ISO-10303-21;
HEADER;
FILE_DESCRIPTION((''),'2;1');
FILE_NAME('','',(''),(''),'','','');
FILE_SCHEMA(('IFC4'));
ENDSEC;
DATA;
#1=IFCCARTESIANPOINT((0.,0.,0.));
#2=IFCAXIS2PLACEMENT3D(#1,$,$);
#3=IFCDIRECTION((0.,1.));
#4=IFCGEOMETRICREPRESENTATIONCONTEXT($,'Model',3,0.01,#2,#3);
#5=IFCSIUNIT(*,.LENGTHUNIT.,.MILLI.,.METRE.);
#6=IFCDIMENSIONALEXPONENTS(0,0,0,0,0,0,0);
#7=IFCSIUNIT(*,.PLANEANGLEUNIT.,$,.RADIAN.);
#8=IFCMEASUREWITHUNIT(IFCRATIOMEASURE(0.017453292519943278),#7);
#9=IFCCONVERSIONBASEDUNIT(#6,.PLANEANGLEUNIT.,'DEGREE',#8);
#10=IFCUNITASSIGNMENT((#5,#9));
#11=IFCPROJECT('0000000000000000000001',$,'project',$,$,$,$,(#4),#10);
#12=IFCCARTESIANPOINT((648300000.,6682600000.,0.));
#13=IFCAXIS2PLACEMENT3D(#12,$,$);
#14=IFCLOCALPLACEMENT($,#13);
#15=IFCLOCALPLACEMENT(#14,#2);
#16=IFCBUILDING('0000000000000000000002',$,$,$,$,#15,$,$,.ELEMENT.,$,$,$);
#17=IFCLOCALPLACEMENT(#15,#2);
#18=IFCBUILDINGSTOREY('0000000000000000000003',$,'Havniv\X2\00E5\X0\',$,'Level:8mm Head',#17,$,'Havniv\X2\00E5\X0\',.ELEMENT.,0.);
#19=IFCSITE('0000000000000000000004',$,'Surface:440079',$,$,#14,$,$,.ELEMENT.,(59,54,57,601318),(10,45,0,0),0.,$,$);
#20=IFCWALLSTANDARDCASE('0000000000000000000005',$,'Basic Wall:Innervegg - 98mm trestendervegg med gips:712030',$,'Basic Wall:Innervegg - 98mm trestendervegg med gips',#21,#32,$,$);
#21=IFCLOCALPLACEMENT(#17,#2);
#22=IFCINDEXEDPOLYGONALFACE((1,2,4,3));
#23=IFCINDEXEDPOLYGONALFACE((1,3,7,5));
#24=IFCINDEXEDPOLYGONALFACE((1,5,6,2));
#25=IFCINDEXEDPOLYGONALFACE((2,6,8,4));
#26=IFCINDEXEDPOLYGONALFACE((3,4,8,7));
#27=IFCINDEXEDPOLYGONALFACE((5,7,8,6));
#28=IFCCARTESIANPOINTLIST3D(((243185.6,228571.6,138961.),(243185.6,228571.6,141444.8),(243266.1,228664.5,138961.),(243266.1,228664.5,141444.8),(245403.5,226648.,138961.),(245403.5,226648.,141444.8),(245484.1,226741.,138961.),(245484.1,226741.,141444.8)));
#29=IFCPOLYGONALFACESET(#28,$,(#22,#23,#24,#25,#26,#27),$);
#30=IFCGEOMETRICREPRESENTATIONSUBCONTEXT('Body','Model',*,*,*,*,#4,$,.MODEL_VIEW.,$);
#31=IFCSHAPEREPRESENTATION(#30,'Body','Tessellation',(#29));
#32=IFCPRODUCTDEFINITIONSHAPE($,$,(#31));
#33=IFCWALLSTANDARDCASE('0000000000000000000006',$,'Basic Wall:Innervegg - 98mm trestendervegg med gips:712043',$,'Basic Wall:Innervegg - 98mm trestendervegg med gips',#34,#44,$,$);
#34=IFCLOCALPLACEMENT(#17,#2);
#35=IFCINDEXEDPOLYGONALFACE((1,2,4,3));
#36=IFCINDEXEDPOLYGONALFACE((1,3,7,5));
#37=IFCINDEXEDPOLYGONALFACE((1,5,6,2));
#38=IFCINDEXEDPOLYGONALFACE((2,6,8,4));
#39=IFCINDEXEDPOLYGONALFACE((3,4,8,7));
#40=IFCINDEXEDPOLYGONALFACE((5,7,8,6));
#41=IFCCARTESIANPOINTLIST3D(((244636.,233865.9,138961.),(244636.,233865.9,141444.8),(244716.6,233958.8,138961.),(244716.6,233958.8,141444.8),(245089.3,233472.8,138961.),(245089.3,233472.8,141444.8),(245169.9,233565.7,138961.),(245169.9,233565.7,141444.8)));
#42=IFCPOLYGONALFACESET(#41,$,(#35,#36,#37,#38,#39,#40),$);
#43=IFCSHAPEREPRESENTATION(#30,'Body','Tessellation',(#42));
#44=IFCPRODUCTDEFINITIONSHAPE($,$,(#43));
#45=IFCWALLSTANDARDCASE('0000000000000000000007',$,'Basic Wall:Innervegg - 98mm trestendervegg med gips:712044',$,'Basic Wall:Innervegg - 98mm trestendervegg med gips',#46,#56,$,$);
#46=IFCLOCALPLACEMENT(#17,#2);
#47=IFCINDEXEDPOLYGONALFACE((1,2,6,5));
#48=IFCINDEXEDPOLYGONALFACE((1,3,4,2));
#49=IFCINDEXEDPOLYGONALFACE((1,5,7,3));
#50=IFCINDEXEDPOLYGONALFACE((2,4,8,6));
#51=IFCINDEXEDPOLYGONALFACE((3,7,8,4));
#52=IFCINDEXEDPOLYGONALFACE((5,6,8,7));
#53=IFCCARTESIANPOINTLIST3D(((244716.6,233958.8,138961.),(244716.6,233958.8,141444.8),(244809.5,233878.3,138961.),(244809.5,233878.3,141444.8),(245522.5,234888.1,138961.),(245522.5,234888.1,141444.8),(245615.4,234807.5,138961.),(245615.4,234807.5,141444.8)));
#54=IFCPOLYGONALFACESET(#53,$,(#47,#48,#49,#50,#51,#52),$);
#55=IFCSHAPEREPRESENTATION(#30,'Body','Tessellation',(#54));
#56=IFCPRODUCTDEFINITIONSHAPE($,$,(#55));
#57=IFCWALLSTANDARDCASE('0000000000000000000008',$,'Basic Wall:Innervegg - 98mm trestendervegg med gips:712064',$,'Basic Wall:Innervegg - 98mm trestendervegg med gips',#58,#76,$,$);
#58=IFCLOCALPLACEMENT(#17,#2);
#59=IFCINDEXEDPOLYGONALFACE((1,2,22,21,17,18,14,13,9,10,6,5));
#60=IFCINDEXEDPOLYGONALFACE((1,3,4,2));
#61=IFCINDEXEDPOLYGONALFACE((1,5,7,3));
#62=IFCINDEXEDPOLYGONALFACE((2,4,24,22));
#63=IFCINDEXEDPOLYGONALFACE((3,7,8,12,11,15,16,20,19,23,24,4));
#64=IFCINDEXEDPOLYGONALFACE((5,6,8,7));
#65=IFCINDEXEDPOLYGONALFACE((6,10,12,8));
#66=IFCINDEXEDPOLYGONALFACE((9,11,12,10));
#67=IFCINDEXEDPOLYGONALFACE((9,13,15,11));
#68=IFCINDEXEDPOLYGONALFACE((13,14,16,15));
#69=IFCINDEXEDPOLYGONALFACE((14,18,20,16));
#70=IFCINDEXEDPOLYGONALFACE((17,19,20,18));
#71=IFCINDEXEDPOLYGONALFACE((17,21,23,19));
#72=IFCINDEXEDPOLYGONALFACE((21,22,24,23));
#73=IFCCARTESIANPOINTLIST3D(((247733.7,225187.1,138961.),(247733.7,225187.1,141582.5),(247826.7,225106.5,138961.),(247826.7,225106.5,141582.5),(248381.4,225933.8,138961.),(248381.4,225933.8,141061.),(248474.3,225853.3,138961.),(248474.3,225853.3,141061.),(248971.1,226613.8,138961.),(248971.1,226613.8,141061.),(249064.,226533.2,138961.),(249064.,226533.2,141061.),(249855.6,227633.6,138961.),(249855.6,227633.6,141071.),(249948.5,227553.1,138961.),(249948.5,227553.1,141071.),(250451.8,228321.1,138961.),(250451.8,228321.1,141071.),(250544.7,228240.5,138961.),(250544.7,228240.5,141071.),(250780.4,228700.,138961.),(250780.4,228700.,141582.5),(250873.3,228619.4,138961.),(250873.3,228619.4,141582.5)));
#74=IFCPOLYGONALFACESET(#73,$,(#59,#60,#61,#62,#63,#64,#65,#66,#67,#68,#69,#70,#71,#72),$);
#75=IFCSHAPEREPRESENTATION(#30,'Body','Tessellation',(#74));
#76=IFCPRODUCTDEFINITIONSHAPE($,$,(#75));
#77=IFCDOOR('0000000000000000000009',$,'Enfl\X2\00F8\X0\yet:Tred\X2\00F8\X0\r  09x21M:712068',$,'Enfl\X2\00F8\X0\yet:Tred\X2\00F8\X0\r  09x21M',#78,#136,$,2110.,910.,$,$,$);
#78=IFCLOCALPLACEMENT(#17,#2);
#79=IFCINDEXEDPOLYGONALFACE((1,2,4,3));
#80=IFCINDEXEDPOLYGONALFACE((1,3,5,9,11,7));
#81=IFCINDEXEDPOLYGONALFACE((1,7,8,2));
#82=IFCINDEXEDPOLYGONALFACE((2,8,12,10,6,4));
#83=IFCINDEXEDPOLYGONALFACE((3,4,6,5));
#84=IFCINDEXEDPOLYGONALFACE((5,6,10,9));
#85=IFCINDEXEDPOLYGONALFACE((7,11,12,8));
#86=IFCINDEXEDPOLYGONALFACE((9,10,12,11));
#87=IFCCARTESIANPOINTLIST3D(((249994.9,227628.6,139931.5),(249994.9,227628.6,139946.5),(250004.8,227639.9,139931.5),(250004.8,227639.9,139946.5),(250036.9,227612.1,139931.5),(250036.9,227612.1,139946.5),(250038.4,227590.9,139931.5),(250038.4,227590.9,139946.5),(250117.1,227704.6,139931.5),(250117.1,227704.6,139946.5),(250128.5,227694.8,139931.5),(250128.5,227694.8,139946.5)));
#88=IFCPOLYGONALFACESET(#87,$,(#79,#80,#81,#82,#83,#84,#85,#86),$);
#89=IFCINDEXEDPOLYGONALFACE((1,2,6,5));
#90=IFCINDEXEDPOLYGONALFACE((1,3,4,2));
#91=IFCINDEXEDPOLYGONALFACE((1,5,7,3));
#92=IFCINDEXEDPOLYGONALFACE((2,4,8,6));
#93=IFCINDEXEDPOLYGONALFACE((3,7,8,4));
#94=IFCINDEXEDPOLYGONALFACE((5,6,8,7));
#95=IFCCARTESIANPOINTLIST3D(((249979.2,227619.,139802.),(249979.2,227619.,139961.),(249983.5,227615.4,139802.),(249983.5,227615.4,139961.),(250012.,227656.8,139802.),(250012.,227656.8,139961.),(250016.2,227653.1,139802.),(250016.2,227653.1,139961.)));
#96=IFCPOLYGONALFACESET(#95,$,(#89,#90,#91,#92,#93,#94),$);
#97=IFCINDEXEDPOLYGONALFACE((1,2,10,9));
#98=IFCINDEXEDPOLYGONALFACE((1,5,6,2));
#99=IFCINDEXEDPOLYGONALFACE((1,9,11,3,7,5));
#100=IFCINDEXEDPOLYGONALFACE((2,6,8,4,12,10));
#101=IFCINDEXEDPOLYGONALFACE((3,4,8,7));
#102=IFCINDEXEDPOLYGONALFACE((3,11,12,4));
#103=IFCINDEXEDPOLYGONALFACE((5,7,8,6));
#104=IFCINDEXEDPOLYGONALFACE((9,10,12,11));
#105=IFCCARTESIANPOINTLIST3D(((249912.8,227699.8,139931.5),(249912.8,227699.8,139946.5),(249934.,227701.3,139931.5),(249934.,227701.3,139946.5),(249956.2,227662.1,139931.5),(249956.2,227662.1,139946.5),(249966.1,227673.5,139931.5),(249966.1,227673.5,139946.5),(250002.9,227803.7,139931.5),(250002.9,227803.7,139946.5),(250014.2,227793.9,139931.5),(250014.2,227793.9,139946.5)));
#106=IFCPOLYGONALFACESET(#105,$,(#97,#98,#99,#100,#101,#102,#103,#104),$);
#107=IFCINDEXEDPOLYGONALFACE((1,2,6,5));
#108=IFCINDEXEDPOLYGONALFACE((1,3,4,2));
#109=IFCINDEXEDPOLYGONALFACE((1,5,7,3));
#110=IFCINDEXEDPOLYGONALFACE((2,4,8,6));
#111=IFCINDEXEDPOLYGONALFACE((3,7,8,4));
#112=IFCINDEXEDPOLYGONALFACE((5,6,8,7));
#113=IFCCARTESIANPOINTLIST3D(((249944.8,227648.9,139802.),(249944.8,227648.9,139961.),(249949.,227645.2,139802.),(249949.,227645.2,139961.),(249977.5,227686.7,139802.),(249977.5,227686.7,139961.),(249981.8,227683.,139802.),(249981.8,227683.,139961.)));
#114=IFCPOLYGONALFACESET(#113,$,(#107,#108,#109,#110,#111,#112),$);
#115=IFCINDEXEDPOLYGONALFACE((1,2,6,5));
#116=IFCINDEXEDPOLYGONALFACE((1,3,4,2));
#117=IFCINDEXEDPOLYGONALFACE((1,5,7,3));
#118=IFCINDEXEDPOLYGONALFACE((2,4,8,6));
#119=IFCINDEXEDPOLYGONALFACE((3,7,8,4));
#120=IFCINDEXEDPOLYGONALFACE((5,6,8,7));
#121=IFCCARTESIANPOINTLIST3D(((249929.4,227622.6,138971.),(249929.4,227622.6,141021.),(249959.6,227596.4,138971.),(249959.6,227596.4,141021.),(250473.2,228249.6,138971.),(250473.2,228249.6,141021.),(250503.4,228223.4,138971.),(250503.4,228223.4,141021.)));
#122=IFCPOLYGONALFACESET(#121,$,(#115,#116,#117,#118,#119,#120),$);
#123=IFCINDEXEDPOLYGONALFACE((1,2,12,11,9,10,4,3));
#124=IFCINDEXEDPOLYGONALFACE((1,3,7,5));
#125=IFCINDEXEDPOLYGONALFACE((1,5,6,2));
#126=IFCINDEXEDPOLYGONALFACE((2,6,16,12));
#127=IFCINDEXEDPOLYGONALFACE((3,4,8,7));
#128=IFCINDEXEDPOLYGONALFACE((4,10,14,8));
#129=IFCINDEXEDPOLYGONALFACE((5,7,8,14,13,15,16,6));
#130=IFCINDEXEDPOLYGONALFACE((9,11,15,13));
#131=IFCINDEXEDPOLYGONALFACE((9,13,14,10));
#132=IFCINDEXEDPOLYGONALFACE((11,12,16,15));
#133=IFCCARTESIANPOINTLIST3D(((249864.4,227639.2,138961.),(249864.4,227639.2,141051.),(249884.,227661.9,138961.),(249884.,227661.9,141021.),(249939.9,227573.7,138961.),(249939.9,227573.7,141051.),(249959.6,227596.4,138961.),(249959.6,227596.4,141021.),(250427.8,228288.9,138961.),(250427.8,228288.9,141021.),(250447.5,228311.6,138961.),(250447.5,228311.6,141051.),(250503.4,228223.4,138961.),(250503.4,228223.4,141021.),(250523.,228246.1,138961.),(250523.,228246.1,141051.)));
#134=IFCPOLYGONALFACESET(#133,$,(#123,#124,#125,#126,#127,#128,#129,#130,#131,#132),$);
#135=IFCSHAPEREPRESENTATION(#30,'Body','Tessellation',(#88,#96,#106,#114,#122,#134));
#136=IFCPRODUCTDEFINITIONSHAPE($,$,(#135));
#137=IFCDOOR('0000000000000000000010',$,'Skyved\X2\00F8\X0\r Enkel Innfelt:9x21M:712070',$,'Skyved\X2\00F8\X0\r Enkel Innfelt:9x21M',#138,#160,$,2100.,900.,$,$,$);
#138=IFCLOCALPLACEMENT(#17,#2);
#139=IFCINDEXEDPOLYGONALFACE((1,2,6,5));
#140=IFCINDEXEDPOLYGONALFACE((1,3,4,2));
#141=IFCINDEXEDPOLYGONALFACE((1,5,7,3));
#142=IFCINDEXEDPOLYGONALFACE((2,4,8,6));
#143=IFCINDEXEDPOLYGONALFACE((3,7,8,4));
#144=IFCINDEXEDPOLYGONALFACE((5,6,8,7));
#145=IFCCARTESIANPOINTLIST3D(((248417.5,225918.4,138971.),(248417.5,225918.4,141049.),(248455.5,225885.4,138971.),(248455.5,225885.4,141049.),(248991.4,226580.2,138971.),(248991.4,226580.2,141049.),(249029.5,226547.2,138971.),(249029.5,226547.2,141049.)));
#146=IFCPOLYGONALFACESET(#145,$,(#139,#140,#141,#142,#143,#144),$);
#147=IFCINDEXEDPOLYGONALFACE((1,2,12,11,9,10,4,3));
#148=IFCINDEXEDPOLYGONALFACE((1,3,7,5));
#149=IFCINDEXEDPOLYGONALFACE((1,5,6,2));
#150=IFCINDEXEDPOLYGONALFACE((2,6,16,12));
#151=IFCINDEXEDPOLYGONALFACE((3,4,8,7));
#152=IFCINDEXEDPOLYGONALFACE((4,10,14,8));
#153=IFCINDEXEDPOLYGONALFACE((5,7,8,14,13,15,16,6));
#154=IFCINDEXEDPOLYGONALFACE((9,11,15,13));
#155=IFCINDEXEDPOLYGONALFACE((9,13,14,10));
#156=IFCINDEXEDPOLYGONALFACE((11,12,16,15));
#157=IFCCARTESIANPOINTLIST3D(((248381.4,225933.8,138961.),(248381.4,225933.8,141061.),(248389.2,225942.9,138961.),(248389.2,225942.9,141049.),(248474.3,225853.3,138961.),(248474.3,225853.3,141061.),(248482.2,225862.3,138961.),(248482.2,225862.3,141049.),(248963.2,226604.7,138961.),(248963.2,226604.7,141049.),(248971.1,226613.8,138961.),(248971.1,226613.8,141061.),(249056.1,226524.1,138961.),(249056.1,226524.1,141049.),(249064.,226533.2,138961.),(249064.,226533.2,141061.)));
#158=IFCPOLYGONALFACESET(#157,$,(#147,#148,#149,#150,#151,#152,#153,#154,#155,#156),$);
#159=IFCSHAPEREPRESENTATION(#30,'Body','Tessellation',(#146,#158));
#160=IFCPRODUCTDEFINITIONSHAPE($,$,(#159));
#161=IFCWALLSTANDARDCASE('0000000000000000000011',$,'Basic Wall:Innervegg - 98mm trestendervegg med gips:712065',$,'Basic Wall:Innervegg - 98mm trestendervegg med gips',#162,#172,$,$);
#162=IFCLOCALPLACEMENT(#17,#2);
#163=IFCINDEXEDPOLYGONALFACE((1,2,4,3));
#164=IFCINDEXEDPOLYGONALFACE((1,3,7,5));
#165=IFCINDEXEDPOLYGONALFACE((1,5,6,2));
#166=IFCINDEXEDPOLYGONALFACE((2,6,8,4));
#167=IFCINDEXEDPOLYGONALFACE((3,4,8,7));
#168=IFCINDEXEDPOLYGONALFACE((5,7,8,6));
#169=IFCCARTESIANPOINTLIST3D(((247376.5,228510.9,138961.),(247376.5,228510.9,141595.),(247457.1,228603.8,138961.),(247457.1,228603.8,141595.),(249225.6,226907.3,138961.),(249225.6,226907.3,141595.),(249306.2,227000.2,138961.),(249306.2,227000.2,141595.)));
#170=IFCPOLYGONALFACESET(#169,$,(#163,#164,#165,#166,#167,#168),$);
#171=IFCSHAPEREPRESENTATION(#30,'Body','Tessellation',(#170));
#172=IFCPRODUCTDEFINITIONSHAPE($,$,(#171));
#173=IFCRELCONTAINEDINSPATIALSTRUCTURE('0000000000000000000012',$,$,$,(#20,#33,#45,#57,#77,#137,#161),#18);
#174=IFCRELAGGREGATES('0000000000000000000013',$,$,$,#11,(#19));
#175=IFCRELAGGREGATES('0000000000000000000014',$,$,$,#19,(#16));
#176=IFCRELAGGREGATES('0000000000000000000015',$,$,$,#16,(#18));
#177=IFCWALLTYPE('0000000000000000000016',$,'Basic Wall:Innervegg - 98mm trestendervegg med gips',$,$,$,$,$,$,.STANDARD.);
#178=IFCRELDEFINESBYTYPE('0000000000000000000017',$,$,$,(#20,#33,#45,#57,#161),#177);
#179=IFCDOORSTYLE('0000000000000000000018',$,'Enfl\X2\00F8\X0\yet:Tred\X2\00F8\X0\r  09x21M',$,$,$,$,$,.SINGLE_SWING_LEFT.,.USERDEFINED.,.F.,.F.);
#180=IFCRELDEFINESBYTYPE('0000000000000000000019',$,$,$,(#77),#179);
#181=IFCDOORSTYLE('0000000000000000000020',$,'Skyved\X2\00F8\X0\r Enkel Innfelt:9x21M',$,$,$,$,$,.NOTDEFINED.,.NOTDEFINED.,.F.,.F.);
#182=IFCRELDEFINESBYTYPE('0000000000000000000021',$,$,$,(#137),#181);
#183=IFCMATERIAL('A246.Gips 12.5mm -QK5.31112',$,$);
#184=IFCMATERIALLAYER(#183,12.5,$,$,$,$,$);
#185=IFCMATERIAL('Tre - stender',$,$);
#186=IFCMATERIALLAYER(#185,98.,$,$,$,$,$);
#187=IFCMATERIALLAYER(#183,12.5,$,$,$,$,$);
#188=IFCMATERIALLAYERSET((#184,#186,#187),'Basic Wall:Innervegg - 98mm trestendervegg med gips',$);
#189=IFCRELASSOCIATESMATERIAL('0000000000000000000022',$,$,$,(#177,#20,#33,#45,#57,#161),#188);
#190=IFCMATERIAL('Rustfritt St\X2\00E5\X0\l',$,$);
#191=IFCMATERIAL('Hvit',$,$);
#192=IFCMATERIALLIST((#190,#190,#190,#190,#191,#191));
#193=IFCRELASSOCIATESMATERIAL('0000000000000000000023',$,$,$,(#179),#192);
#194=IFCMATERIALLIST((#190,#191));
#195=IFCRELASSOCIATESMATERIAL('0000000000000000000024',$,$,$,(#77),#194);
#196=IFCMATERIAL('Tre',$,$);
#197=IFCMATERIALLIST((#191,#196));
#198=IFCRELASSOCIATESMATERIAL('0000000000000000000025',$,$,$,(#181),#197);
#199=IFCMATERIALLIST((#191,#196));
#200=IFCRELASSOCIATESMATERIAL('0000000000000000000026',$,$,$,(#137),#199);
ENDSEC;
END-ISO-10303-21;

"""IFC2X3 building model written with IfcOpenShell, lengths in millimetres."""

from ifc_helpers import new_model, entity, si_unit, converted_unit, direction, frame, frame_2d, origin, origin_2d_with_axis, place, context, subcontext, project, spatial, polyline, rectangle, outline, extrude, source, transform, mapped, material, material_list, layer, layer_set, layer_usage, type_object, type_shapes, element, fill, save


model = new_model("IFC2X3")

# Units and contexts
model_context = context("Model", 3, precision=0.01, world=origin(), true_north=direction((0.0, 1.0)))
body_context = subcontext(model_context, "Body", "Model", "MODEL_VIEW")
ifc_project = project(units=[si_unit("LENGTHUNIT", "METRE", prefix="MILLI"), converted_unit("PLANEANGLEUNIT", "DEGREE", entity("IfcRatioMeasure", 0.017453292519943278), si_unit("PLANEANGLEUNIT", "RADIAN"), dimensions=[0, 0, 0, 0, 0, 0, 0])], contexts=[model_context])

# Site, building, storey
site_placement = place(None, frame((648300000.0, 6682600000.0, 0.0)))
site = spatial("IfcSite", under=ifc_project, at=site_placement, Name="Surface:440079", CompositionType="ELEMENT", RefLatitude=(59, 54, 57, 601318), RefLongitude=(10, 45, 0, 0), RefElevation=0.0)
building_placement = place(site_placement, origin())
building = spatial("IfcBuilding", under=site, at=building_placement, CompositionType="ELEMENT")
storey_placement = place(building_placement, origin())
storey = spatial("IfcBuildingStorey", under=building, at=storey_placement, Name="Havnivå", ObjectType="Level:8mm Head", LongName="Havnivå", CompositionType="ELEMENT", Elevation=0.0)

# Shared definitions
ifc_material_1 = material(Name="A246.Gips 12.5mm -QK5.31112")
ifc_layer_1 = layer(ifc_material_1, 12.5)
ifc_material_2 = material(Name="Tre - stender")
ifc_layer_2 = layer(ifc_material_2, 98.0)
ifc_layer_3 = layer(ifc_material_1, 12.5)
ifc_layer_set_1 = layer_set([ifc_layer_1, ifc_layer_2, ifc_layer_3], Name="Basic Wall:Innervegg - 98mm trestendervegg med gips")
wall_type_1 = type_object("IfcWallType", Name="Basic Wall:Innervegg - 98mm trestendervegg med gips", PredefinedType="STANDARD", material=ifc_layer_set_1)
ifc_material_3 = material(Name="Rustfritt Stål")
ifc_material_4 = material(Name="Hvit")
ifc_material_list_1 = material_list([ifc_material_3, ifc_material_3, ifc_material_3, ifc_material_3, ifc_material_4, ifc_material_4])
door_style_1 = type_object("IfcDoorStyle", Name="Enfløyet:Tredør  09x21M", ConstructionType="USERDEFINED", OperationType="SINGLE_SWING_LEFT", ParameterTakesPrecedence=False, Sizeable=False, material=ifc_material_list_1)
shared_shape_1 = source(origin(), body_context, "Body", "SweptSolid", [
    extrude(outline(polyline([(-33.3, -50.8), (24.2, -50.8), (24.2, 86.7), (9.2, 86.7), (9.2, -35.8), (-33.3, -35.8), (-33.3, -50.8)])), frame((771.7, 121.9, 970.5), z_axis=(0.0, 0.0, 1.0), x_axis=(0.0, 1.0, 0.0)), (0.0, 0.0, 1.0), 15.0),
    extrude(rectangle(XDim=5.6, YDim=50.0, at=frame_2d((0.0, 0.0), x_axis=(1.0, 0.0))), frame((815.0, 85.8, 841.0), z_axis=(0.0, 0.0, 1.0), x_axis=(0.0, -1.0, 0.0)), (0.0, 0.0, 1.0), 159.0),
    extrude(outline(polyline([(-50.8, -33.3), (-35.8, -33.3), (-35.8, 9.2), (86.7, 9.2), (86.7, 24.2), (-50.8, 24.2), (-50.8, -33.3)])), frame((771.7, 4.1, 970.5), z_axis=(0.0, 0.0, 1.0), x_axis=(-1.0, 0.0, 0.0)), (0.0, 0.0, 1.0), 15.0),
    extrude(rectangle(XDim=50.0, YDim=5.6, at=frame_2d((0.0, 0.0), x_axis=(1.0, 0.0))), frame((815.0, 40.2, 841.0)), (0.0, 0.0, 1.0), 159.0),
    extrude(rectangle(XDim=830.0, YDim=40.0, at=origin_2d_with_axis()), frame((455.0, 63.0, 10.0), z_axis=(0.0, 0.0, 1.0), x_axis=(-1.0, 0.0, 0.0)), (0.0, 0.0, 1.0), 2050.0),
    extrude(outline(polyline([(415.0, -1037.5), (445.0, -1037.5), (445.0, 1052.5), (-445.0, 1052.5), (-445.0, -1037.5), (-415.0, -1037.5), (-415.0, 1022.5), (415.0, 1022.5), (415.0, -1037.5)])), frame((455.0, 83.0, 1037.5), z_axis=(0.0, -1.0, 0.0), x_axis=(1.0, 0.0, 0.0)), (0.0, 0.0, 1.0), 100.0),
])
type_shapes(door_style_1, [shared_shape_1])

# Shared definitions
ifc_material_5 = material(Name="Tre")

# Walls
ifc_layer_usage_1 = layer_usage(ifc_layer_set_1, "AXIS2", "POSITIVE", -61.5)
wall_1_placement = place(storey_placement, frame((243225.9, 228618.1, 138961.0), z_axis=(0.0, 0.0, 1.0), x_axis=(0.755467, -0.655187, 0.0)))
element("IfcWallStandardCase", 1, at=wall_1_placement, inside=storey, type_object=wall_type_1, material=ifc_layer_usage_1, Name="Basic Wall:Innervegg - 98mm trestendervegg med gips:712030", ObjectType="Basic Wall:Innervegg - 98mm trestendervegg med gips", context=body_context, shape_type="SweptSolid", body=[
    extrude(rectangle(XDim=2935.9, YDim=123.0, at=frame_2d((1468.0, 0.0), x_axis=(-1.0, 0.0))), origin(), (0.0, 0.0, 1.0), 2483.8),
])
ifc_layer_usage_2 = layer_usage(ifc_layer_set_1, "AXIS2", "POSITIVE", -61.5)
wall_2_placement = place(storey_placement, frame((245129.6, 233519.3, 138961.0), z_axis=(0.0, 0.0, 1.0), x_axis=(-0.755467, 0.655187, 0.0)))
element("IfcWallStandardCase", 2, at=wall_2_placement, inside=storey, type_object=wall_type_1, material=ifc_layer_usage_2, Name="Basic Wall:Innervegg - 98mm trestendervegg med gips:712043", ObjectType="Basic Wall:Innervegg - 98mm trestendervegg med gips", context=body_context, shape_type="SweptSolid", body=[
    extrude(rectangle(XDim=600.0, YDim=123.0, at=frame_2d((300.0, 0.0), x_axis=(-1.0, 0.0))), origin(), (0.0, 0.0, 1.0), 2483.8),
])
ifc_layer_usage_3 = layer_usage(ifc_layer_set_1, "AXIS2", "POSITIVE", -61.5)
wall_3_placement = place(storey_placement, frame((244763.1, 233918.5, 138961.0), z_axis=(0.0, 0.0, 1.0), x_axis=(0.655187, 0.755467, 0.0)))
element("IfcWallStandardCase", 3, at=wall_3_placement, inside=storey, type_object=wall_type_1, material=ifc_layer_usage_3, Name="Basic Wall:Innervegg - 98mm trestendervegg med gips:712044", ObjectType="Basic Wall:Innervegg - 98mm trestendervegg med gips", context=body_context, shape_type="SweptSolid", body=[
    extrude(rectangle(XDim=1230.0, YDim=123.0, at=frame_2d((615.0, 0.0), x_axis=(-1.0, 0.0))), origin(), (0.0, 0.0, 1.0), 2483.8),
])

# Wall, openings, doors
ifc_layer_usage_4 = layer_usage(ifc_layer_set_1, "AXIS2", "POSITIVE", -61.5)
wall_4_placement = place(storey_placement, frame((247780.2, 225146.8, 138961.0), z_axis=(0.0, 0.0, 1.0), x_axis=(0.655187, 0.755467, 0.0)))
wall_4 = element("IfcWallStandardCase", 4, at=wall_4_placement, inside=storey, type_object=wall_type_1, material=ifc_layer_usage_4, Name="Basic Wall:Innervegg - 98mm trestendervegg med gips:712064", ObjectType="Basic Wall:Innervegg - 98mm trestendervegg med gips", context=body_context, shape_type="SweptSolid", body=[
    extrude(rectangle(XDim=4650.0, YDim=123.0, at=frame_2d((2325.0, 0.0), x_axis=(1.0, 0.0))), origin(), (0.0, 0.0, 1.0), 2621.5),
])
opening_1_placement = place(wall_4_placement, frame((4148.5, 61.5, 0.0)))
opening_1 = element("IfcOpeningElement", 5, at=opening_1_placement, cuts=wall_4, ObjectType="Opening", context=body_context, shape_type="SweptSolid", body=[
    extrude(rectangle(XDim=2110.0, YDim=910.0, at=frame_2d((1055.0, 455.0), x_axis=(1.0, 0.0))), frame((0.0, 0.0, 0.0), z_axis=(0.0, -1.0, 0.0), x_axis=(0.0, 0.0, 1.0)), (0.0, 0.0, 1.0), 123.0),
])
opening_2_placement = place(wall_4_placement, frame((1888.5, 61.5, 0.0)))
opening_2 = element("IfcOpeningElement", 6, at=opening_2_placement, cuts=wall_4, ObjectType="Opening", context=body_context, shape_type="SweptSolid", body=[
    extrude(rectangle(XDim=2100.0, YDim=900.0, at=frame_2d((1050.0, 450.0), x_axis=(1.0, 0.0))), frame((0.0, 0.0, 0.0), z_axis=(0.0, -1.0, 0.0), x_axis=(0.0, 0.0, 1.0)), (0.0, 0.0, 1.0), 123.0),
])
ifc_material_list_2 = material_list([ifc_material_3, ifc_material_4])
door_1_placement = place(opening_1_placement, frame((0.0, -20.0, 0.0), z_axis=(0.0, 0.0, 1.0), x_axis=(-1.0, 0.0, 0.0)))
door_1 = element("IfcDoor", 7, at=door_1_placement, inside=storey, type_object=door_style_1, material=ifc_material_list_2, Name="Enfløyet:Tredør  09x21M:712068", ObjectType="Enfløyet:Tredør  09x21M", OverallHeight=2110.0, OverallWidth=910.0, context=body_context, shape_type="MappedRepresentation", body=[
    mapped(shared_shape_1, transform((0.0, 0.0, 0.0), scale=1.0)),
])
fill(opening_1, door_1)
ifc_material_list_3 = material_list([ifc_material_4, ifc_material_5])
ifc_material_list_4 = material_list([ifc_material_4, ifc_material_5])
door_style_2 = type_object("IfcDoorStyle", Name="Skyvedør Enkel Innfelt:9x21M", ConstructionType="NOTDEFINED", OperationType="NOTDEFINED", ParameterTakesPrecedence=False, Sizeable=False, material=ifc_material_list_4)
shared_shape_2 = source(origin(), body_context, "Body", "SweptSolid", [
    extrude(rectangle(XDim=876.0, YDim=50.4, at=frame_2d((0.0, 0.0), x_axis=(1.0, 0.0))), frame((450.0, 62.5, 10.0), z_axis=(0.0, 0.0, 1.0), x_axis=(-1.0, 0.0, 0.0)), (0.0, 0.0, 1.0), 2078.0),
    extrude(outline(polyline([(-1047.0, -438.0), (-1047.0, -450.0), (1053.0, -450.0), (1053.0, 450.0), (-1047.0, 450.0), (-1047.0, 438.0), (1041.0, 438.0), (1041.0, -438.0), (-1047.0, -438.0)])), frame((450.0, 0.0, 1047.0), z_axis=(0.0, -1.0, 0.0), x_axis=(0.0, 0.0, 1.0)), (0.0, 0.0, -1.0), 123.0),
])
type_shapes(door_style_2, [shared_shape_2])
door_2_placement = place(opening_2_placement, frame((0.0, 0.0, 0.0), z_axis=(0.0, 0.0, 1.0), x_axis=(-1.0, 0.0, 0.0)))
door_2 = element("IfcDoor", 8, at=door_2_placement, inside=storey, type_object=door_style_2, material=ifc_material_list_3, Name="Skyvedør Enkel Innfelt:9x21M:712070", ObjectType="Skyvedør Enkel Innfelt:9x21M", OverallHeight=2100.0, OverallWidth=900.0, context=body_context, shape_type="MappedRepresentation", body=[
    mapped(shared_shape_2, transform((0.0, 0.0, 0.0), scale=1.0)),
])
fill(opening_2, door_2)

# Wall
ifc_layer_usage_5 = layer_usage(ifc_layer_set_1, "AXIS2", "NEGATIVE", 61.5)
wall_5_placement = place(storey_placement, frame((249265.9, 226953.7, 138961.0), z_axis=(0.0, 0.0, 1.0), x_axis=(-0.755467, 0.655187, 0.0)))
element("IfcWallStandardCase", 9, at=wall_5_placement, inside=storey, type_object=wall_type_1, material=ifc_layer_usage_5, Name="Basic Wall:Innervegg - 98mm trestendervegg med gips:712065", ObjectType="Basic Wall:Innervegg - 98mm trestendervegg med gips", context=body_context, shape_type="SweptSolid", body=[
    extrude(rectangle(XDim=2447.6, YDim=123.0, at=frame_2d((1223.8, 0.0), x_axis=(-1.0, 0.0))), origin(), (0.0, 0.0, 1.0), 2634.0),
])

save(model, "model.ifc")
